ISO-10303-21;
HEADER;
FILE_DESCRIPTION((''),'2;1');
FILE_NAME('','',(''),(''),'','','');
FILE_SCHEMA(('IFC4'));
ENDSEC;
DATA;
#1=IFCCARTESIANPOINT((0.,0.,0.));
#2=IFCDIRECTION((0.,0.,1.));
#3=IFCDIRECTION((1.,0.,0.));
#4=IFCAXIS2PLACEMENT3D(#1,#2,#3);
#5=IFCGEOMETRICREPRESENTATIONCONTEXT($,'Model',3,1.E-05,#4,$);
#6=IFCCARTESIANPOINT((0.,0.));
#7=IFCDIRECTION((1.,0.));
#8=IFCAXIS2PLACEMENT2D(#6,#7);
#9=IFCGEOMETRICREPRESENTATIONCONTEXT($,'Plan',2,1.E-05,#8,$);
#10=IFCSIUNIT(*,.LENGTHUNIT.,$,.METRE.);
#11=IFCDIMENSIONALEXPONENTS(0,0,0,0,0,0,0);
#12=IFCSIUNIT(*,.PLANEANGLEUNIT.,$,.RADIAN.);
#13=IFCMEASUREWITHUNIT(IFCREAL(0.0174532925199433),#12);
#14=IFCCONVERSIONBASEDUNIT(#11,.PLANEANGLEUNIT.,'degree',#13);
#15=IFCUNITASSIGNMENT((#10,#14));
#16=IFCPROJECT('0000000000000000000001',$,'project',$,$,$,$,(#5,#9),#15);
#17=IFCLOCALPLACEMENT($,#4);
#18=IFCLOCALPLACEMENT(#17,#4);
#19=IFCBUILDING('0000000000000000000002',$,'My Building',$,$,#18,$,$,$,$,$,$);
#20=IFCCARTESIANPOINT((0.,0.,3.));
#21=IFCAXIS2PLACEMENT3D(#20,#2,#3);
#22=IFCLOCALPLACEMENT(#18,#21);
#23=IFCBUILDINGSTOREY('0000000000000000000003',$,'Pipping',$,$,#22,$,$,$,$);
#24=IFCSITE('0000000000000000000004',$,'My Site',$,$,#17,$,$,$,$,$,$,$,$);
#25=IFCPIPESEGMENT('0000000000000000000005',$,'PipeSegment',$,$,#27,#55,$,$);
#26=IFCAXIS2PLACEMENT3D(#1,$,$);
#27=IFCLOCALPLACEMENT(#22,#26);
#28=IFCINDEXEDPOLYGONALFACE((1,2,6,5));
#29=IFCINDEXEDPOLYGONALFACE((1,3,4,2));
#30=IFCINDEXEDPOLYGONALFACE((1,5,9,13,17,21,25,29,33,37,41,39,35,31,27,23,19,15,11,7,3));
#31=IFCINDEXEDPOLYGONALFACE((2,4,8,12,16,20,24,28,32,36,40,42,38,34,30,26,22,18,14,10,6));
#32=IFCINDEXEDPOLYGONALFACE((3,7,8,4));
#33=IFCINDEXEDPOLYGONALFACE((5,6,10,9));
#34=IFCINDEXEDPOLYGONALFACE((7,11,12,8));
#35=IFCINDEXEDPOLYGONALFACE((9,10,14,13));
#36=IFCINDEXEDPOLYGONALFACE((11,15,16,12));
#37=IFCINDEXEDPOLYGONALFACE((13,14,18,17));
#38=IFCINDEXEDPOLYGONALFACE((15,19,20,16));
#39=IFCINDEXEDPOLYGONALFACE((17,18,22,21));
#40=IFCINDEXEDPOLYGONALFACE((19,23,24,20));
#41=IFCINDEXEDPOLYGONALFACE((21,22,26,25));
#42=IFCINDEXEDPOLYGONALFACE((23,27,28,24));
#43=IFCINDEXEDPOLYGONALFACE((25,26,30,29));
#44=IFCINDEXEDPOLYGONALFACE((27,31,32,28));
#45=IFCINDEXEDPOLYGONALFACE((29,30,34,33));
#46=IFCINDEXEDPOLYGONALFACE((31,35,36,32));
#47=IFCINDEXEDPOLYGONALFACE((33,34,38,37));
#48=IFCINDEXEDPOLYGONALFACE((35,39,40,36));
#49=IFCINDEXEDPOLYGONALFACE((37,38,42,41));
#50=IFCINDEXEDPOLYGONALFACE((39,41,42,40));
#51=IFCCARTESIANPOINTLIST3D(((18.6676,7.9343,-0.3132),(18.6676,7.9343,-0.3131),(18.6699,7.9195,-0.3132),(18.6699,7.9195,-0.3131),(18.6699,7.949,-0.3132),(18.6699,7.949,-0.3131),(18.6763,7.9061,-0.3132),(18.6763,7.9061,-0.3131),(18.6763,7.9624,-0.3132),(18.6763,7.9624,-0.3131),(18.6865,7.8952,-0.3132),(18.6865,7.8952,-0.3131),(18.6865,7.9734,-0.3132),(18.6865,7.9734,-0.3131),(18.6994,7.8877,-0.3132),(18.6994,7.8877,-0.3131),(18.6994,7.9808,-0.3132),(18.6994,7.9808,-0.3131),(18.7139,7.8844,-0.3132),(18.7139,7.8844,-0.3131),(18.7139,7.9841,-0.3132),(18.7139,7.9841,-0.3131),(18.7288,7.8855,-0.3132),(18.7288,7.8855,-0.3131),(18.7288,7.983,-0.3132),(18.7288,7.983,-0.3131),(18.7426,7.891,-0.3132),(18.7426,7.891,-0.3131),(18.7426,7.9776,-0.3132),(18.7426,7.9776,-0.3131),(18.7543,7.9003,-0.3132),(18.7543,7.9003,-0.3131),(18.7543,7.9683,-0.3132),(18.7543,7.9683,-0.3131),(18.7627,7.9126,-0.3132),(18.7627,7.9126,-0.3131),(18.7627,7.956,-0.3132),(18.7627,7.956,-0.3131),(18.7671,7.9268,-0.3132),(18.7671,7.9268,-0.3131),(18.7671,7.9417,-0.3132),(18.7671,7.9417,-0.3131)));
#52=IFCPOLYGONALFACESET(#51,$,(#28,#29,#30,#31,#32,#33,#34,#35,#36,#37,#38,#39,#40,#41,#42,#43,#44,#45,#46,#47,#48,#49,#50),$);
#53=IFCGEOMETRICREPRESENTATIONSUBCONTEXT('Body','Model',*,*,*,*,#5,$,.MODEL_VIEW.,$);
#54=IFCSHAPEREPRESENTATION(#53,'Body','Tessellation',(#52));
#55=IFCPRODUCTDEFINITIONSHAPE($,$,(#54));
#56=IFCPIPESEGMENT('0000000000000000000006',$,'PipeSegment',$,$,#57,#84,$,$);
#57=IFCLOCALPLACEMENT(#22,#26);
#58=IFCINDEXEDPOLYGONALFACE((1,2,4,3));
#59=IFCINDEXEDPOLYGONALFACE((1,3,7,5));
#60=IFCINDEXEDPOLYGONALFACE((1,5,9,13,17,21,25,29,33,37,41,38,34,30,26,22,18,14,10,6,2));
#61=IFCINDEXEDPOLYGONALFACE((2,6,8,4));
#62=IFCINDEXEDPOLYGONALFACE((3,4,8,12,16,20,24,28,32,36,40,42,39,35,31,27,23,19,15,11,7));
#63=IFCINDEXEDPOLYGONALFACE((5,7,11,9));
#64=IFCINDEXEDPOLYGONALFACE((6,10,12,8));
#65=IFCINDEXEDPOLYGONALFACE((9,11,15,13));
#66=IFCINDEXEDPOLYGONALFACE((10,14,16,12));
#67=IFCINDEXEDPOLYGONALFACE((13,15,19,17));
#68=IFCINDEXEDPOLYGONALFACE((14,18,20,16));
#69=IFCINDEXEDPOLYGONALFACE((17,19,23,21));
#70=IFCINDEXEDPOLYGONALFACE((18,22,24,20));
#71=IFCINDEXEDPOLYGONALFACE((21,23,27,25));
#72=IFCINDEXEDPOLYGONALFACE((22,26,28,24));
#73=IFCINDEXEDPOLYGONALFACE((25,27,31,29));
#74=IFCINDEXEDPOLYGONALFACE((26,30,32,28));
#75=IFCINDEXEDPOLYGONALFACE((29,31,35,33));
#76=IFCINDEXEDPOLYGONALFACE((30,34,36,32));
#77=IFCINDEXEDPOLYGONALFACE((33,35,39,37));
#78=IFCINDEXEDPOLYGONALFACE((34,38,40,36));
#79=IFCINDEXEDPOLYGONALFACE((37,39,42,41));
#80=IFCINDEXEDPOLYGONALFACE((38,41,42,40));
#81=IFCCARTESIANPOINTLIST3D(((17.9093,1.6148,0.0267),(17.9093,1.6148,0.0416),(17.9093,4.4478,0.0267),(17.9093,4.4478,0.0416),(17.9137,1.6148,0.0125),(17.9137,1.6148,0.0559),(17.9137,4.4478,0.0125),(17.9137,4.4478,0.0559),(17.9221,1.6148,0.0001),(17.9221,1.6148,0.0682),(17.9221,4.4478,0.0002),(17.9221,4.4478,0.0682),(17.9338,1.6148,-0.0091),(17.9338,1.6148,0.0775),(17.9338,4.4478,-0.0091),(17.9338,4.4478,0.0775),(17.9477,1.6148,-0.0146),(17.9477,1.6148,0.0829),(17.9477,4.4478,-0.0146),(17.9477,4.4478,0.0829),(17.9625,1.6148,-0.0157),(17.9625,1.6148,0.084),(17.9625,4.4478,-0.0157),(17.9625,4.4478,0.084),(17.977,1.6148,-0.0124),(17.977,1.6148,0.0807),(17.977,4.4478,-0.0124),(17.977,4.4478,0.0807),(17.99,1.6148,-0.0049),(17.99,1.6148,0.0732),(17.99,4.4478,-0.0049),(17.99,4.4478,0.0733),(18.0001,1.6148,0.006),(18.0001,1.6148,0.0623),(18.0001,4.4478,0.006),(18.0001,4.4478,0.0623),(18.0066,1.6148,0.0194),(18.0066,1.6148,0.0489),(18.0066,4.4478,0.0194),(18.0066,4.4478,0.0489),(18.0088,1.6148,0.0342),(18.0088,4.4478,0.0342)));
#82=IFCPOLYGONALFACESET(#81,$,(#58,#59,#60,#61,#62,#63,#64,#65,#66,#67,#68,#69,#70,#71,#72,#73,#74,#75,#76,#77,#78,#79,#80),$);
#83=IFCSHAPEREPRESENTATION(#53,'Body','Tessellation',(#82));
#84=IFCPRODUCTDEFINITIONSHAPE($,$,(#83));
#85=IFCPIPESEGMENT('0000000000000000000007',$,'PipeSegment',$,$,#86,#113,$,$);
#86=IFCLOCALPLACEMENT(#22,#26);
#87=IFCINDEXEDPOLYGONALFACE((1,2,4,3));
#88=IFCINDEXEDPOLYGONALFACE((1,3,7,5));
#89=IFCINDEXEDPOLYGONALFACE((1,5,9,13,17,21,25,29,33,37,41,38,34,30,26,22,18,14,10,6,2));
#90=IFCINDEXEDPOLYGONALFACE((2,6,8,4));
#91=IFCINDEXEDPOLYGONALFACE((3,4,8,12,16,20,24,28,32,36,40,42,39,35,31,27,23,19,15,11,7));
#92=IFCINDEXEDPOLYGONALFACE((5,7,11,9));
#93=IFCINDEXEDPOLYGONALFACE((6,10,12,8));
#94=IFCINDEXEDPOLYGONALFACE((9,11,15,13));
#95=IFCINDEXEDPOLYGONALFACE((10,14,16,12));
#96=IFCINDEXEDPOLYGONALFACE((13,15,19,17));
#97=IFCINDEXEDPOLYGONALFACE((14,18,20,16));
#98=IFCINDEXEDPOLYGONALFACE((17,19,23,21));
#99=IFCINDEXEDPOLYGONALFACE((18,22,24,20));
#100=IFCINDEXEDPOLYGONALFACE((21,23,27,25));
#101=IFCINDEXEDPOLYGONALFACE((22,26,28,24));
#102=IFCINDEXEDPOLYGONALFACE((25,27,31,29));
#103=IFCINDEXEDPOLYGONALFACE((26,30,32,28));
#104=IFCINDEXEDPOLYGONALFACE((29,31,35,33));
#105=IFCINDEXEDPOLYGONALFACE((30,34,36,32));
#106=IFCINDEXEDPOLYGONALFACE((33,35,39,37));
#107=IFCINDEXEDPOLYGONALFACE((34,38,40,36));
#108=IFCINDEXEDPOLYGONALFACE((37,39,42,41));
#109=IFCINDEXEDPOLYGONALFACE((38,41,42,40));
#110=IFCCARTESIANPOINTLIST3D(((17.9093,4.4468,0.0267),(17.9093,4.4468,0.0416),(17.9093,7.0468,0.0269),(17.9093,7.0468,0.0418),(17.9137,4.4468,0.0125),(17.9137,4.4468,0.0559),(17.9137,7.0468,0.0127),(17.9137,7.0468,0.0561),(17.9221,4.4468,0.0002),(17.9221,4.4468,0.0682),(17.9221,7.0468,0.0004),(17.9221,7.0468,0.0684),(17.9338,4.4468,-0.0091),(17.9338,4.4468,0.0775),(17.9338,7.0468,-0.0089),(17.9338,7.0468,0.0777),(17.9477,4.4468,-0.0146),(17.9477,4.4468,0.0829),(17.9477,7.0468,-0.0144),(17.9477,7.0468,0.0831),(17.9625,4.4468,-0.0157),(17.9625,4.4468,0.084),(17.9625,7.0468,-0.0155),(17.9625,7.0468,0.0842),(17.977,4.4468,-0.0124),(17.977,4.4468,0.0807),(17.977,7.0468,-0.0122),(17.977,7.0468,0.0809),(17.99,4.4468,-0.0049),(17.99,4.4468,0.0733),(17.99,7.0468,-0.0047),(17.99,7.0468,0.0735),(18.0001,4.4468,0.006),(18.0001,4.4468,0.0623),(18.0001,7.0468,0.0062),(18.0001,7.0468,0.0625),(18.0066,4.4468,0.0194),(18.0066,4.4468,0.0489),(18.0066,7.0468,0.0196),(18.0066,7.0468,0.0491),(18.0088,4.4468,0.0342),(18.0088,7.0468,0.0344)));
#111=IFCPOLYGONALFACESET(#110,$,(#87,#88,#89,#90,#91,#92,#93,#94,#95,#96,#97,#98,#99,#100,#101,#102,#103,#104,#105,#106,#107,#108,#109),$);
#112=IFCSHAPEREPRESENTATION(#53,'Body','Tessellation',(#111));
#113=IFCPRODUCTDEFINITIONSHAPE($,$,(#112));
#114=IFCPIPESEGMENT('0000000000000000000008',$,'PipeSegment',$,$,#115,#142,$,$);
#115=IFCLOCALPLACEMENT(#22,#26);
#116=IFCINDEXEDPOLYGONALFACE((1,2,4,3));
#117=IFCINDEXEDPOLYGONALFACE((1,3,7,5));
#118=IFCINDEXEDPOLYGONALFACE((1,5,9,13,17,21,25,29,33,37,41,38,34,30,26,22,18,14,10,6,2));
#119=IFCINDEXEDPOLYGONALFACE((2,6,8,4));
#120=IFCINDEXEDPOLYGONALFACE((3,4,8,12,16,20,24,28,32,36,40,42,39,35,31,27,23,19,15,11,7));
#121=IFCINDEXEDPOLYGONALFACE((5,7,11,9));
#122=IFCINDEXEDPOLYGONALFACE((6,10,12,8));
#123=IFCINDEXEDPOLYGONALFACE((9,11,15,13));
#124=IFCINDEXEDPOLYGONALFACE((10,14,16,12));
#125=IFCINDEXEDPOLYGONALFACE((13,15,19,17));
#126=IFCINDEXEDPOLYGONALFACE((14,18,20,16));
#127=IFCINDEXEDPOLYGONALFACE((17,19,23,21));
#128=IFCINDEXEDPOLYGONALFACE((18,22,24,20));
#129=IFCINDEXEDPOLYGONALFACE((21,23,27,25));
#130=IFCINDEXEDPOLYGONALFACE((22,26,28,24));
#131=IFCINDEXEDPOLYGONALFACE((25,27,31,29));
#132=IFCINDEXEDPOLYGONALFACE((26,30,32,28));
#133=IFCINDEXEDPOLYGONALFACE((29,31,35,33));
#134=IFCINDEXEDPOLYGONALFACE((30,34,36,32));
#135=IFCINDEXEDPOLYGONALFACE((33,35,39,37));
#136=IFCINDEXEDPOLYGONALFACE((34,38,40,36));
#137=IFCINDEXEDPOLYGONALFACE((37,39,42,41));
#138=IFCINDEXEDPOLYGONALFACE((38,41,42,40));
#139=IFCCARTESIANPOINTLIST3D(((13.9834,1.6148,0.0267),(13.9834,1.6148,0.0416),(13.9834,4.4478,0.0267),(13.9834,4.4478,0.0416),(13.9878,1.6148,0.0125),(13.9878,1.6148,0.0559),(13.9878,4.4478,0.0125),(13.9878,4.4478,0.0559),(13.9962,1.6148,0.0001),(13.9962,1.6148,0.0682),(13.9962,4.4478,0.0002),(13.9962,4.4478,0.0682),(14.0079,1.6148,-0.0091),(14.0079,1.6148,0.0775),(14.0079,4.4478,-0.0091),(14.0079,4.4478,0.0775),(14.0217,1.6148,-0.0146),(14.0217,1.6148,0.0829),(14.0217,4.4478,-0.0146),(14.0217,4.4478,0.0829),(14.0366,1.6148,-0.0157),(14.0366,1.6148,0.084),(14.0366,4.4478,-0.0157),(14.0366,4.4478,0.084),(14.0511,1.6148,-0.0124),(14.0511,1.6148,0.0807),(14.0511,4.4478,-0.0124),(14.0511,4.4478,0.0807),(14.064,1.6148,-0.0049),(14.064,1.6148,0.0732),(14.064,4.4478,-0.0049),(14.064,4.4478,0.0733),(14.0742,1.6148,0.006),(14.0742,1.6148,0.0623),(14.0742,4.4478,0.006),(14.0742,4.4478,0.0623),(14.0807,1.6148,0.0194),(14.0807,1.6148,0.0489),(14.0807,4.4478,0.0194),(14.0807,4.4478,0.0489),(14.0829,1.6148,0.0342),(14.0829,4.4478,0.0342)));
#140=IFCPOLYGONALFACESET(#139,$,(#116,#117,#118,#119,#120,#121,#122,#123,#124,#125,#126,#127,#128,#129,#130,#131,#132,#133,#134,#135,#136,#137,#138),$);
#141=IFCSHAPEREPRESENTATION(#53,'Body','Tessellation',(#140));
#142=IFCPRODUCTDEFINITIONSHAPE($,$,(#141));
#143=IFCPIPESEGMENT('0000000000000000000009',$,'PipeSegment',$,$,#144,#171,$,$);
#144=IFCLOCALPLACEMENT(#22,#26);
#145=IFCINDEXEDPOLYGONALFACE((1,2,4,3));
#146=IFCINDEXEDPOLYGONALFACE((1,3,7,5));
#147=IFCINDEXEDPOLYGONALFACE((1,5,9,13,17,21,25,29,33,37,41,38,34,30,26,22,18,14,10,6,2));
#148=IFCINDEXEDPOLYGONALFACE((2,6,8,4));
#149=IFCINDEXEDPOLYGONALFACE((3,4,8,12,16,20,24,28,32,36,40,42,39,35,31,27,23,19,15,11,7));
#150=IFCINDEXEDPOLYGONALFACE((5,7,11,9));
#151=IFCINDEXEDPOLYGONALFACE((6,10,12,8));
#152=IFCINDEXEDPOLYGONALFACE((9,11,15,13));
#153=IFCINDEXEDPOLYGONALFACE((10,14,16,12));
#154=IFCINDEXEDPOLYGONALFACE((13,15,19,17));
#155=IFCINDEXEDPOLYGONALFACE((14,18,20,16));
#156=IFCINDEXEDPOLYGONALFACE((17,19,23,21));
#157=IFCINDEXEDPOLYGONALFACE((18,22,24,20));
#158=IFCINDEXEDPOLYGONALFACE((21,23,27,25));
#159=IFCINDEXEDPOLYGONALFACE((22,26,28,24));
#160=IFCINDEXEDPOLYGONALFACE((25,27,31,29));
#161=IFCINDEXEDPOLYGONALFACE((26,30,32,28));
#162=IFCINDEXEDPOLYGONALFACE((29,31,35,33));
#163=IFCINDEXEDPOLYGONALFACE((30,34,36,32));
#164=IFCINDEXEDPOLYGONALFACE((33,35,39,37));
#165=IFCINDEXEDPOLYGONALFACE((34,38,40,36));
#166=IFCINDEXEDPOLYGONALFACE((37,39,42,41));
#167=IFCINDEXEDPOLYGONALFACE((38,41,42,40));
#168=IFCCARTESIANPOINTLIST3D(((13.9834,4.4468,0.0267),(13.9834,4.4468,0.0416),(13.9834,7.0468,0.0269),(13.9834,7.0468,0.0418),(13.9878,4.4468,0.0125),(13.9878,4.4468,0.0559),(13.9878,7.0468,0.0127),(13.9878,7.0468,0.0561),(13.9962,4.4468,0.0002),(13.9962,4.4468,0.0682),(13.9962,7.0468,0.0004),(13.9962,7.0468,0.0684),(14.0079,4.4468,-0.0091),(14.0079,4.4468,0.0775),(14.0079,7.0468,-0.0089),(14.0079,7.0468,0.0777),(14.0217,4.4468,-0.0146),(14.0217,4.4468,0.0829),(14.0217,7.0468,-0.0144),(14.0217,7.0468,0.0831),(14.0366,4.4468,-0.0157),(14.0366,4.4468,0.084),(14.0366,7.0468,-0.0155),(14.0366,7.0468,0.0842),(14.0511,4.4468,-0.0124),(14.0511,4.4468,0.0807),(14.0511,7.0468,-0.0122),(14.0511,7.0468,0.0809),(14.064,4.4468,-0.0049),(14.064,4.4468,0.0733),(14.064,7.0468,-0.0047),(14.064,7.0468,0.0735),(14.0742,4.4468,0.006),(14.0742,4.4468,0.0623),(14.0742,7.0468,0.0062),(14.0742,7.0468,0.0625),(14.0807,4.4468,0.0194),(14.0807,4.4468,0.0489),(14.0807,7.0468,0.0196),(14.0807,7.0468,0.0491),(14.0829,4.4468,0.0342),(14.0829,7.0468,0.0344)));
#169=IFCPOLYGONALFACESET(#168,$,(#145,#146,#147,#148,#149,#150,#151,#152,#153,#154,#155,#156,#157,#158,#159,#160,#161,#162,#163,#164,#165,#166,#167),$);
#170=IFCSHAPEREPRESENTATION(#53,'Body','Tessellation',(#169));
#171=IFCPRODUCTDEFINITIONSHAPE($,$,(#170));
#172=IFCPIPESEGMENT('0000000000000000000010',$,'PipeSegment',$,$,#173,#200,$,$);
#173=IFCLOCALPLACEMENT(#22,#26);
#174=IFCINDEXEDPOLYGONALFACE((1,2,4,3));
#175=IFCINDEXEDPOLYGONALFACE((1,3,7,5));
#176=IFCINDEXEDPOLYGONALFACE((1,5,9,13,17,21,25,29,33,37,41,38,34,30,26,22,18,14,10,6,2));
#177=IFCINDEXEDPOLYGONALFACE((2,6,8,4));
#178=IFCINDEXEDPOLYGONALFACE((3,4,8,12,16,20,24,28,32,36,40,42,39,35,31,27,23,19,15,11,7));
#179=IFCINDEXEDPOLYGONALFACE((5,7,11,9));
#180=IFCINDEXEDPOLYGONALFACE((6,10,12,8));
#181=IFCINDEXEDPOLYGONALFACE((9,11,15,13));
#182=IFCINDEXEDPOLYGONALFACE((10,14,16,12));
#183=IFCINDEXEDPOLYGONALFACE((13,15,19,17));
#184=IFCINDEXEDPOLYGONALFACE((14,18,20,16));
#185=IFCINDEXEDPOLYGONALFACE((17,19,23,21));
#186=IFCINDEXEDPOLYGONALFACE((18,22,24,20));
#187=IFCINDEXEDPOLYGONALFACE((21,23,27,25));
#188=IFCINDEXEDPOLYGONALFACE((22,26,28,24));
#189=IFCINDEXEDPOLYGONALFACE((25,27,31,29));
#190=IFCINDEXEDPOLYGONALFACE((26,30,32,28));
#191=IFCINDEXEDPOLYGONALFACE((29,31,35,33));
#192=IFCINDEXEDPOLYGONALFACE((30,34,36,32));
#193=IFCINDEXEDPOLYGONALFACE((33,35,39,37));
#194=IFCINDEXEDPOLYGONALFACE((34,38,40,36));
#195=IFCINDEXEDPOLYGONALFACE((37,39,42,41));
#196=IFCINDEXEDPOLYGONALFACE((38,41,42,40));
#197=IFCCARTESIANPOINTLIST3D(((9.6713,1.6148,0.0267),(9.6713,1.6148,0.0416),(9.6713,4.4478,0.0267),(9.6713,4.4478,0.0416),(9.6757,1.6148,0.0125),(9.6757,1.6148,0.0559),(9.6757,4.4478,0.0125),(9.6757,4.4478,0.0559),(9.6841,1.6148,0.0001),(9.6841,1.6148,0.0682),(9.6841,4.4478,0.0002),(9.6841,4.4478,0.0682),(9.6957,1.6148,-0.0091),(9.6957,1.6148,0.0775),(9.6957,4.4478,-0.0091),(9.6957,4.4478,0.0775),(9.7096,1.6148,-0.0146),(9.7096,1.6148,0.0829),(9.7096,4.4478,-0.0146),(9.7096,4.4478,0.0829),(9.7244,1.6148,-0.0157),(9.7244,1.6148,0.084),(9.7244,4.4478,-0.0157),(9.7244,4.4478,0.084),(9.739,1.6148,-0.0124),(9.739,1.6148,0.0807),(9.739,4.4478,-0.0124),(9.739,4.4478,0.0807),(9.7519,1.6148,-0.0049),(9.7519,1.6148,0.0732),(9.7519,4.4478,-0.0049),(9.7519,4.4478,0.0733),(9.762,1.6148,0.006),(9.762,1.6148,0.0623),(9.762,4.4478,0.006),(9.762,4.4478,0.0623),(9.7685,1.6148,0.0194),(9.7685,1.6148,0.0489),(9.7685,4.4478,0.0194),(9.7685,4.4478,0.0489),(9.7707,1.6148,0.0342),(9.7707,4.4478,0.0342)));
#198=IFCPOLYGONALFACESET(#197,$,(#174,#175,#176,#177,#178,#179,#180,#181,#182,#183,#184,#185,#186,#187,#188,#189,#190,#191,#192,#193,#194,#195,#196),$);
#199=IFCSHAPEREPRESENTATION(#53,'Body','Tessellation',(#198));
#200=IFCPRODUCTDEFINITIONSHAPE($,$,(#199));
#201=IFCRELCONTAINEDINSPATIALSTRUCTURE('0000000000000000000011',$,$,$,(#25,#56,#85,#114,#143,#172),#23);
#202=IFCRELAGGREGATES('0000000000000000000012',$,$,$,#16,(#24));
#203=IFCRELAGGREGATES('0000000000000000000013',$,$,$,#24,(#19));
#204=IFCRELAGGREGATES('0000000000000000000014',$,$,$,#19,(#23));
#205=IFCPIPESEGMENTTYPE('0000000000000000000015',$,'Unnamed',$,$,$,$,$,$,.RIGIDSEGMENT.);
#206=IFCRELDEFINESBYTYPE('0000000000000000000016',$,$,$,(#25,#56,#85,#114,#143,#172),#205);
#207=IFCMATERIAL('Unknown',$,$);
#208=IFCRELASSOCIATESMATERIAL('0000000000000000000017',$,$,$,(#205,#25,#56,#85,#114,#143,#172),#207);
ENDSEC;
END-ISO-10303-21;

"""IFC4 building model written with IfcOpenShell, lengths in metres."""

from ifc_helpers import new_model, entity, si_unit, converted_unit, frame, origin_with_axes, origin_2d_with_axis, place, context, subcontext, project, spatial, circle, extrude, material, material_profile, profile_set, profile_usage, type_object, element, save


model = new_model("IFC4")

# Units and contexts
model_context = context("Model", 3, precision=1e-05, world=origin_with_axes())
plan_context = context("Plan", 2, precision=1e-05, world=origin_2d_with_axis())
body_context = subcontext(model_context, "Body", "Model", "MODEL_VIEW")
ifc_project = project(units=[si_unit("LENGTHUNIT", "METRE"), converted_unit("PLANEANGLEUNIT", "degree", entity("IfcReal", 0.0174532925199433), si_unit("PLANEANGLEUNIT", "RADIAN"), dimensions=[0, 0, 0, 0, 0, 0, 0])], contexts=[model_context, plan_context])

# Site, building, storey
site_placement = place(None, origin_with_axes())
site = spatial("IfcSite", under=ifc_project, at=site_placement, Name="My Site")
building_placement = place(site_placement, origin_with_axes())
building = spatial("IfcBuilding", under=site, at=building_placement, Name="My Building")
storey_placement = place(building_placement, frame((0.0, 0.0, 3.0), z_axis=(0.0, 0.0, 1.0), x_axis=(1.0, 0.0, 0.0)))
storey = spatial("IfcBuildingStorey", under=building, at=storey_placement, Name="Pipping")

# Pipe segments
ifc_material = material(Name="Unknown")
ifc_material_profile_1 = material_profile(ifc_material, circle(Radius=0.05))
ifc_profile_set_1 = profile_set([ifc_material_profile_1])
ifc_profile_usage_1 = profile_usage(ifc_profile_set_1, cardinal=5)
pipe_segment_type = type_object("IfcPipeSegmentType", Name="Unnamed", PredefinedType="RIGIDSEGMENT", material=ifc_profile_set_1)
pipe_segment_1_placement = place(storey_placement, frame((18.7176, 7.9343, -0.3131), z_axis=(0.0, 0.0, -1.0), x_axis=(-1.0, 0.0, 0.0)))
element("IfcPipeSegment", 1, at=pipe_segment_1_placement, inside=storey, type_object=pipe_segment_type, material=ifc_profile_usage_1, Name="PipeSegment", context=body_context, shape_type="SweptSolid", body=[
    extrude(circle(Radius=0.05), origin_with_axes(), (0.0, 0.0, 1.0), 0.0001),
])
ifc_profile_usage_2 = profile_usage(ifc_profile_set_1, cardinal=5)
pipe_segment_2_placement = place(storey_placement, frame((17.9588, 4.4478, 0.0342), z_axis=(0.0, -1.0, -0.000004), x_axis=(1.0, 0.0, 0.0)))
element("IfcPipeSegment", 2, at=pipe_segment_2_placement, inside=storey, type_object=pipe_segment_type, material=ifc_profile_usage_2, Name="PipeSegment", context=body_context, shape_type="SweptSolid", body=[
    extrude(circle(Radius=0.05), origin_with_axes(), (0.0, 0.0, 1.0), 2.8329),
])
ifc_profile_usage_3 = profile_usage(ifc_profile_set_1, cardinal=5)
pipe_segment_3_placement = place(storey_placement, frame((17.9588, 4.4468, 0.0342), z_axis=(0.0, 1.0, 0.000073), x_axis=(1.0, 0.0, 0.0)))
element("IfcPipeSegment", 3, at=pipe_segment_3_placement, inside=storey, type_object=pipe_segment_type, material=ifc_profile_usage_3, Name="PipeSegment", context=body_context, shape_type="SweptSolid", body=[
    extrude(circle(Radius=0.05), origin_with_axes(), (0.0, 0.0, 1.0), 2.6),
])
ifc_profile_usage_4 = profile_usage(ifc_profile_set_1, cardinal=5)
pipe_segment_4_placement = place(storey_placement, frame((14.0329, 4.4478, 0.0342), z_axis=(0.0, -1.0, -0.000004), x_axis=(1.0, 0.0, 0.0)))
element("IfcPipeSegment", 4, at=pipe_segment_4_placement, inside=storey, type_object=pipe_segment_type, material=ifc_profile_usage_4, Name="PipeSegment", context=body_context, shape_type="SweptSolid", body=[
    extrude(circle(Radius=0.05), origin_with_axes(), (0.0, 0.0, 1.0), 2.8329),
])
ifc_profile_usage_5 = profile_usage(ifc_profile_set_1, cardinal=5)
pipe_segment_5_placement = place(storey_placement, frame((14.0329, 4.4468, 0.0342), z_axis=(0.0, 1.0, 0.000073), x_axis=(1.0, 0.0, 0.0)))
element("IfcPipeSegment", 5, at=pipe_segment_5_placement, inside=storey, type_object=pipe_segment_type, material=ifc_profile_usage_5, Name="PipeSegment", context=body_context, shape_type="SweptSolid", body=[
    extrude(circle(Radius=0.05), origin_with_axes(), (0.0, 0.0, 1.0), 2.6),
])
ifc_profile_usage_6 = profile_usage(ifc_profile_set_1, cardinal=5)
pipe_segment_6_placement = place(storey_placement, frame((9.7207, 4.4478, 0.0342), z_axis=(0.0, -1.0, -0.000004), x_axis=(1.0, 0.0, 0.0)))
element("IfcPipeSegment", 6, at=pipe_segment_6_placement, inside=storey, type_object=pipe_segment_type, material=ifc_profile_usage_6, Name="PipeSegment", context=body_context, shape_type="SweptSolid", body=[
    extrude(circle(Radius=0.05), origin_with_axes(), (0.0, 0.0, 1.0), 2.8329),
])

save(model, "model.ifc")
